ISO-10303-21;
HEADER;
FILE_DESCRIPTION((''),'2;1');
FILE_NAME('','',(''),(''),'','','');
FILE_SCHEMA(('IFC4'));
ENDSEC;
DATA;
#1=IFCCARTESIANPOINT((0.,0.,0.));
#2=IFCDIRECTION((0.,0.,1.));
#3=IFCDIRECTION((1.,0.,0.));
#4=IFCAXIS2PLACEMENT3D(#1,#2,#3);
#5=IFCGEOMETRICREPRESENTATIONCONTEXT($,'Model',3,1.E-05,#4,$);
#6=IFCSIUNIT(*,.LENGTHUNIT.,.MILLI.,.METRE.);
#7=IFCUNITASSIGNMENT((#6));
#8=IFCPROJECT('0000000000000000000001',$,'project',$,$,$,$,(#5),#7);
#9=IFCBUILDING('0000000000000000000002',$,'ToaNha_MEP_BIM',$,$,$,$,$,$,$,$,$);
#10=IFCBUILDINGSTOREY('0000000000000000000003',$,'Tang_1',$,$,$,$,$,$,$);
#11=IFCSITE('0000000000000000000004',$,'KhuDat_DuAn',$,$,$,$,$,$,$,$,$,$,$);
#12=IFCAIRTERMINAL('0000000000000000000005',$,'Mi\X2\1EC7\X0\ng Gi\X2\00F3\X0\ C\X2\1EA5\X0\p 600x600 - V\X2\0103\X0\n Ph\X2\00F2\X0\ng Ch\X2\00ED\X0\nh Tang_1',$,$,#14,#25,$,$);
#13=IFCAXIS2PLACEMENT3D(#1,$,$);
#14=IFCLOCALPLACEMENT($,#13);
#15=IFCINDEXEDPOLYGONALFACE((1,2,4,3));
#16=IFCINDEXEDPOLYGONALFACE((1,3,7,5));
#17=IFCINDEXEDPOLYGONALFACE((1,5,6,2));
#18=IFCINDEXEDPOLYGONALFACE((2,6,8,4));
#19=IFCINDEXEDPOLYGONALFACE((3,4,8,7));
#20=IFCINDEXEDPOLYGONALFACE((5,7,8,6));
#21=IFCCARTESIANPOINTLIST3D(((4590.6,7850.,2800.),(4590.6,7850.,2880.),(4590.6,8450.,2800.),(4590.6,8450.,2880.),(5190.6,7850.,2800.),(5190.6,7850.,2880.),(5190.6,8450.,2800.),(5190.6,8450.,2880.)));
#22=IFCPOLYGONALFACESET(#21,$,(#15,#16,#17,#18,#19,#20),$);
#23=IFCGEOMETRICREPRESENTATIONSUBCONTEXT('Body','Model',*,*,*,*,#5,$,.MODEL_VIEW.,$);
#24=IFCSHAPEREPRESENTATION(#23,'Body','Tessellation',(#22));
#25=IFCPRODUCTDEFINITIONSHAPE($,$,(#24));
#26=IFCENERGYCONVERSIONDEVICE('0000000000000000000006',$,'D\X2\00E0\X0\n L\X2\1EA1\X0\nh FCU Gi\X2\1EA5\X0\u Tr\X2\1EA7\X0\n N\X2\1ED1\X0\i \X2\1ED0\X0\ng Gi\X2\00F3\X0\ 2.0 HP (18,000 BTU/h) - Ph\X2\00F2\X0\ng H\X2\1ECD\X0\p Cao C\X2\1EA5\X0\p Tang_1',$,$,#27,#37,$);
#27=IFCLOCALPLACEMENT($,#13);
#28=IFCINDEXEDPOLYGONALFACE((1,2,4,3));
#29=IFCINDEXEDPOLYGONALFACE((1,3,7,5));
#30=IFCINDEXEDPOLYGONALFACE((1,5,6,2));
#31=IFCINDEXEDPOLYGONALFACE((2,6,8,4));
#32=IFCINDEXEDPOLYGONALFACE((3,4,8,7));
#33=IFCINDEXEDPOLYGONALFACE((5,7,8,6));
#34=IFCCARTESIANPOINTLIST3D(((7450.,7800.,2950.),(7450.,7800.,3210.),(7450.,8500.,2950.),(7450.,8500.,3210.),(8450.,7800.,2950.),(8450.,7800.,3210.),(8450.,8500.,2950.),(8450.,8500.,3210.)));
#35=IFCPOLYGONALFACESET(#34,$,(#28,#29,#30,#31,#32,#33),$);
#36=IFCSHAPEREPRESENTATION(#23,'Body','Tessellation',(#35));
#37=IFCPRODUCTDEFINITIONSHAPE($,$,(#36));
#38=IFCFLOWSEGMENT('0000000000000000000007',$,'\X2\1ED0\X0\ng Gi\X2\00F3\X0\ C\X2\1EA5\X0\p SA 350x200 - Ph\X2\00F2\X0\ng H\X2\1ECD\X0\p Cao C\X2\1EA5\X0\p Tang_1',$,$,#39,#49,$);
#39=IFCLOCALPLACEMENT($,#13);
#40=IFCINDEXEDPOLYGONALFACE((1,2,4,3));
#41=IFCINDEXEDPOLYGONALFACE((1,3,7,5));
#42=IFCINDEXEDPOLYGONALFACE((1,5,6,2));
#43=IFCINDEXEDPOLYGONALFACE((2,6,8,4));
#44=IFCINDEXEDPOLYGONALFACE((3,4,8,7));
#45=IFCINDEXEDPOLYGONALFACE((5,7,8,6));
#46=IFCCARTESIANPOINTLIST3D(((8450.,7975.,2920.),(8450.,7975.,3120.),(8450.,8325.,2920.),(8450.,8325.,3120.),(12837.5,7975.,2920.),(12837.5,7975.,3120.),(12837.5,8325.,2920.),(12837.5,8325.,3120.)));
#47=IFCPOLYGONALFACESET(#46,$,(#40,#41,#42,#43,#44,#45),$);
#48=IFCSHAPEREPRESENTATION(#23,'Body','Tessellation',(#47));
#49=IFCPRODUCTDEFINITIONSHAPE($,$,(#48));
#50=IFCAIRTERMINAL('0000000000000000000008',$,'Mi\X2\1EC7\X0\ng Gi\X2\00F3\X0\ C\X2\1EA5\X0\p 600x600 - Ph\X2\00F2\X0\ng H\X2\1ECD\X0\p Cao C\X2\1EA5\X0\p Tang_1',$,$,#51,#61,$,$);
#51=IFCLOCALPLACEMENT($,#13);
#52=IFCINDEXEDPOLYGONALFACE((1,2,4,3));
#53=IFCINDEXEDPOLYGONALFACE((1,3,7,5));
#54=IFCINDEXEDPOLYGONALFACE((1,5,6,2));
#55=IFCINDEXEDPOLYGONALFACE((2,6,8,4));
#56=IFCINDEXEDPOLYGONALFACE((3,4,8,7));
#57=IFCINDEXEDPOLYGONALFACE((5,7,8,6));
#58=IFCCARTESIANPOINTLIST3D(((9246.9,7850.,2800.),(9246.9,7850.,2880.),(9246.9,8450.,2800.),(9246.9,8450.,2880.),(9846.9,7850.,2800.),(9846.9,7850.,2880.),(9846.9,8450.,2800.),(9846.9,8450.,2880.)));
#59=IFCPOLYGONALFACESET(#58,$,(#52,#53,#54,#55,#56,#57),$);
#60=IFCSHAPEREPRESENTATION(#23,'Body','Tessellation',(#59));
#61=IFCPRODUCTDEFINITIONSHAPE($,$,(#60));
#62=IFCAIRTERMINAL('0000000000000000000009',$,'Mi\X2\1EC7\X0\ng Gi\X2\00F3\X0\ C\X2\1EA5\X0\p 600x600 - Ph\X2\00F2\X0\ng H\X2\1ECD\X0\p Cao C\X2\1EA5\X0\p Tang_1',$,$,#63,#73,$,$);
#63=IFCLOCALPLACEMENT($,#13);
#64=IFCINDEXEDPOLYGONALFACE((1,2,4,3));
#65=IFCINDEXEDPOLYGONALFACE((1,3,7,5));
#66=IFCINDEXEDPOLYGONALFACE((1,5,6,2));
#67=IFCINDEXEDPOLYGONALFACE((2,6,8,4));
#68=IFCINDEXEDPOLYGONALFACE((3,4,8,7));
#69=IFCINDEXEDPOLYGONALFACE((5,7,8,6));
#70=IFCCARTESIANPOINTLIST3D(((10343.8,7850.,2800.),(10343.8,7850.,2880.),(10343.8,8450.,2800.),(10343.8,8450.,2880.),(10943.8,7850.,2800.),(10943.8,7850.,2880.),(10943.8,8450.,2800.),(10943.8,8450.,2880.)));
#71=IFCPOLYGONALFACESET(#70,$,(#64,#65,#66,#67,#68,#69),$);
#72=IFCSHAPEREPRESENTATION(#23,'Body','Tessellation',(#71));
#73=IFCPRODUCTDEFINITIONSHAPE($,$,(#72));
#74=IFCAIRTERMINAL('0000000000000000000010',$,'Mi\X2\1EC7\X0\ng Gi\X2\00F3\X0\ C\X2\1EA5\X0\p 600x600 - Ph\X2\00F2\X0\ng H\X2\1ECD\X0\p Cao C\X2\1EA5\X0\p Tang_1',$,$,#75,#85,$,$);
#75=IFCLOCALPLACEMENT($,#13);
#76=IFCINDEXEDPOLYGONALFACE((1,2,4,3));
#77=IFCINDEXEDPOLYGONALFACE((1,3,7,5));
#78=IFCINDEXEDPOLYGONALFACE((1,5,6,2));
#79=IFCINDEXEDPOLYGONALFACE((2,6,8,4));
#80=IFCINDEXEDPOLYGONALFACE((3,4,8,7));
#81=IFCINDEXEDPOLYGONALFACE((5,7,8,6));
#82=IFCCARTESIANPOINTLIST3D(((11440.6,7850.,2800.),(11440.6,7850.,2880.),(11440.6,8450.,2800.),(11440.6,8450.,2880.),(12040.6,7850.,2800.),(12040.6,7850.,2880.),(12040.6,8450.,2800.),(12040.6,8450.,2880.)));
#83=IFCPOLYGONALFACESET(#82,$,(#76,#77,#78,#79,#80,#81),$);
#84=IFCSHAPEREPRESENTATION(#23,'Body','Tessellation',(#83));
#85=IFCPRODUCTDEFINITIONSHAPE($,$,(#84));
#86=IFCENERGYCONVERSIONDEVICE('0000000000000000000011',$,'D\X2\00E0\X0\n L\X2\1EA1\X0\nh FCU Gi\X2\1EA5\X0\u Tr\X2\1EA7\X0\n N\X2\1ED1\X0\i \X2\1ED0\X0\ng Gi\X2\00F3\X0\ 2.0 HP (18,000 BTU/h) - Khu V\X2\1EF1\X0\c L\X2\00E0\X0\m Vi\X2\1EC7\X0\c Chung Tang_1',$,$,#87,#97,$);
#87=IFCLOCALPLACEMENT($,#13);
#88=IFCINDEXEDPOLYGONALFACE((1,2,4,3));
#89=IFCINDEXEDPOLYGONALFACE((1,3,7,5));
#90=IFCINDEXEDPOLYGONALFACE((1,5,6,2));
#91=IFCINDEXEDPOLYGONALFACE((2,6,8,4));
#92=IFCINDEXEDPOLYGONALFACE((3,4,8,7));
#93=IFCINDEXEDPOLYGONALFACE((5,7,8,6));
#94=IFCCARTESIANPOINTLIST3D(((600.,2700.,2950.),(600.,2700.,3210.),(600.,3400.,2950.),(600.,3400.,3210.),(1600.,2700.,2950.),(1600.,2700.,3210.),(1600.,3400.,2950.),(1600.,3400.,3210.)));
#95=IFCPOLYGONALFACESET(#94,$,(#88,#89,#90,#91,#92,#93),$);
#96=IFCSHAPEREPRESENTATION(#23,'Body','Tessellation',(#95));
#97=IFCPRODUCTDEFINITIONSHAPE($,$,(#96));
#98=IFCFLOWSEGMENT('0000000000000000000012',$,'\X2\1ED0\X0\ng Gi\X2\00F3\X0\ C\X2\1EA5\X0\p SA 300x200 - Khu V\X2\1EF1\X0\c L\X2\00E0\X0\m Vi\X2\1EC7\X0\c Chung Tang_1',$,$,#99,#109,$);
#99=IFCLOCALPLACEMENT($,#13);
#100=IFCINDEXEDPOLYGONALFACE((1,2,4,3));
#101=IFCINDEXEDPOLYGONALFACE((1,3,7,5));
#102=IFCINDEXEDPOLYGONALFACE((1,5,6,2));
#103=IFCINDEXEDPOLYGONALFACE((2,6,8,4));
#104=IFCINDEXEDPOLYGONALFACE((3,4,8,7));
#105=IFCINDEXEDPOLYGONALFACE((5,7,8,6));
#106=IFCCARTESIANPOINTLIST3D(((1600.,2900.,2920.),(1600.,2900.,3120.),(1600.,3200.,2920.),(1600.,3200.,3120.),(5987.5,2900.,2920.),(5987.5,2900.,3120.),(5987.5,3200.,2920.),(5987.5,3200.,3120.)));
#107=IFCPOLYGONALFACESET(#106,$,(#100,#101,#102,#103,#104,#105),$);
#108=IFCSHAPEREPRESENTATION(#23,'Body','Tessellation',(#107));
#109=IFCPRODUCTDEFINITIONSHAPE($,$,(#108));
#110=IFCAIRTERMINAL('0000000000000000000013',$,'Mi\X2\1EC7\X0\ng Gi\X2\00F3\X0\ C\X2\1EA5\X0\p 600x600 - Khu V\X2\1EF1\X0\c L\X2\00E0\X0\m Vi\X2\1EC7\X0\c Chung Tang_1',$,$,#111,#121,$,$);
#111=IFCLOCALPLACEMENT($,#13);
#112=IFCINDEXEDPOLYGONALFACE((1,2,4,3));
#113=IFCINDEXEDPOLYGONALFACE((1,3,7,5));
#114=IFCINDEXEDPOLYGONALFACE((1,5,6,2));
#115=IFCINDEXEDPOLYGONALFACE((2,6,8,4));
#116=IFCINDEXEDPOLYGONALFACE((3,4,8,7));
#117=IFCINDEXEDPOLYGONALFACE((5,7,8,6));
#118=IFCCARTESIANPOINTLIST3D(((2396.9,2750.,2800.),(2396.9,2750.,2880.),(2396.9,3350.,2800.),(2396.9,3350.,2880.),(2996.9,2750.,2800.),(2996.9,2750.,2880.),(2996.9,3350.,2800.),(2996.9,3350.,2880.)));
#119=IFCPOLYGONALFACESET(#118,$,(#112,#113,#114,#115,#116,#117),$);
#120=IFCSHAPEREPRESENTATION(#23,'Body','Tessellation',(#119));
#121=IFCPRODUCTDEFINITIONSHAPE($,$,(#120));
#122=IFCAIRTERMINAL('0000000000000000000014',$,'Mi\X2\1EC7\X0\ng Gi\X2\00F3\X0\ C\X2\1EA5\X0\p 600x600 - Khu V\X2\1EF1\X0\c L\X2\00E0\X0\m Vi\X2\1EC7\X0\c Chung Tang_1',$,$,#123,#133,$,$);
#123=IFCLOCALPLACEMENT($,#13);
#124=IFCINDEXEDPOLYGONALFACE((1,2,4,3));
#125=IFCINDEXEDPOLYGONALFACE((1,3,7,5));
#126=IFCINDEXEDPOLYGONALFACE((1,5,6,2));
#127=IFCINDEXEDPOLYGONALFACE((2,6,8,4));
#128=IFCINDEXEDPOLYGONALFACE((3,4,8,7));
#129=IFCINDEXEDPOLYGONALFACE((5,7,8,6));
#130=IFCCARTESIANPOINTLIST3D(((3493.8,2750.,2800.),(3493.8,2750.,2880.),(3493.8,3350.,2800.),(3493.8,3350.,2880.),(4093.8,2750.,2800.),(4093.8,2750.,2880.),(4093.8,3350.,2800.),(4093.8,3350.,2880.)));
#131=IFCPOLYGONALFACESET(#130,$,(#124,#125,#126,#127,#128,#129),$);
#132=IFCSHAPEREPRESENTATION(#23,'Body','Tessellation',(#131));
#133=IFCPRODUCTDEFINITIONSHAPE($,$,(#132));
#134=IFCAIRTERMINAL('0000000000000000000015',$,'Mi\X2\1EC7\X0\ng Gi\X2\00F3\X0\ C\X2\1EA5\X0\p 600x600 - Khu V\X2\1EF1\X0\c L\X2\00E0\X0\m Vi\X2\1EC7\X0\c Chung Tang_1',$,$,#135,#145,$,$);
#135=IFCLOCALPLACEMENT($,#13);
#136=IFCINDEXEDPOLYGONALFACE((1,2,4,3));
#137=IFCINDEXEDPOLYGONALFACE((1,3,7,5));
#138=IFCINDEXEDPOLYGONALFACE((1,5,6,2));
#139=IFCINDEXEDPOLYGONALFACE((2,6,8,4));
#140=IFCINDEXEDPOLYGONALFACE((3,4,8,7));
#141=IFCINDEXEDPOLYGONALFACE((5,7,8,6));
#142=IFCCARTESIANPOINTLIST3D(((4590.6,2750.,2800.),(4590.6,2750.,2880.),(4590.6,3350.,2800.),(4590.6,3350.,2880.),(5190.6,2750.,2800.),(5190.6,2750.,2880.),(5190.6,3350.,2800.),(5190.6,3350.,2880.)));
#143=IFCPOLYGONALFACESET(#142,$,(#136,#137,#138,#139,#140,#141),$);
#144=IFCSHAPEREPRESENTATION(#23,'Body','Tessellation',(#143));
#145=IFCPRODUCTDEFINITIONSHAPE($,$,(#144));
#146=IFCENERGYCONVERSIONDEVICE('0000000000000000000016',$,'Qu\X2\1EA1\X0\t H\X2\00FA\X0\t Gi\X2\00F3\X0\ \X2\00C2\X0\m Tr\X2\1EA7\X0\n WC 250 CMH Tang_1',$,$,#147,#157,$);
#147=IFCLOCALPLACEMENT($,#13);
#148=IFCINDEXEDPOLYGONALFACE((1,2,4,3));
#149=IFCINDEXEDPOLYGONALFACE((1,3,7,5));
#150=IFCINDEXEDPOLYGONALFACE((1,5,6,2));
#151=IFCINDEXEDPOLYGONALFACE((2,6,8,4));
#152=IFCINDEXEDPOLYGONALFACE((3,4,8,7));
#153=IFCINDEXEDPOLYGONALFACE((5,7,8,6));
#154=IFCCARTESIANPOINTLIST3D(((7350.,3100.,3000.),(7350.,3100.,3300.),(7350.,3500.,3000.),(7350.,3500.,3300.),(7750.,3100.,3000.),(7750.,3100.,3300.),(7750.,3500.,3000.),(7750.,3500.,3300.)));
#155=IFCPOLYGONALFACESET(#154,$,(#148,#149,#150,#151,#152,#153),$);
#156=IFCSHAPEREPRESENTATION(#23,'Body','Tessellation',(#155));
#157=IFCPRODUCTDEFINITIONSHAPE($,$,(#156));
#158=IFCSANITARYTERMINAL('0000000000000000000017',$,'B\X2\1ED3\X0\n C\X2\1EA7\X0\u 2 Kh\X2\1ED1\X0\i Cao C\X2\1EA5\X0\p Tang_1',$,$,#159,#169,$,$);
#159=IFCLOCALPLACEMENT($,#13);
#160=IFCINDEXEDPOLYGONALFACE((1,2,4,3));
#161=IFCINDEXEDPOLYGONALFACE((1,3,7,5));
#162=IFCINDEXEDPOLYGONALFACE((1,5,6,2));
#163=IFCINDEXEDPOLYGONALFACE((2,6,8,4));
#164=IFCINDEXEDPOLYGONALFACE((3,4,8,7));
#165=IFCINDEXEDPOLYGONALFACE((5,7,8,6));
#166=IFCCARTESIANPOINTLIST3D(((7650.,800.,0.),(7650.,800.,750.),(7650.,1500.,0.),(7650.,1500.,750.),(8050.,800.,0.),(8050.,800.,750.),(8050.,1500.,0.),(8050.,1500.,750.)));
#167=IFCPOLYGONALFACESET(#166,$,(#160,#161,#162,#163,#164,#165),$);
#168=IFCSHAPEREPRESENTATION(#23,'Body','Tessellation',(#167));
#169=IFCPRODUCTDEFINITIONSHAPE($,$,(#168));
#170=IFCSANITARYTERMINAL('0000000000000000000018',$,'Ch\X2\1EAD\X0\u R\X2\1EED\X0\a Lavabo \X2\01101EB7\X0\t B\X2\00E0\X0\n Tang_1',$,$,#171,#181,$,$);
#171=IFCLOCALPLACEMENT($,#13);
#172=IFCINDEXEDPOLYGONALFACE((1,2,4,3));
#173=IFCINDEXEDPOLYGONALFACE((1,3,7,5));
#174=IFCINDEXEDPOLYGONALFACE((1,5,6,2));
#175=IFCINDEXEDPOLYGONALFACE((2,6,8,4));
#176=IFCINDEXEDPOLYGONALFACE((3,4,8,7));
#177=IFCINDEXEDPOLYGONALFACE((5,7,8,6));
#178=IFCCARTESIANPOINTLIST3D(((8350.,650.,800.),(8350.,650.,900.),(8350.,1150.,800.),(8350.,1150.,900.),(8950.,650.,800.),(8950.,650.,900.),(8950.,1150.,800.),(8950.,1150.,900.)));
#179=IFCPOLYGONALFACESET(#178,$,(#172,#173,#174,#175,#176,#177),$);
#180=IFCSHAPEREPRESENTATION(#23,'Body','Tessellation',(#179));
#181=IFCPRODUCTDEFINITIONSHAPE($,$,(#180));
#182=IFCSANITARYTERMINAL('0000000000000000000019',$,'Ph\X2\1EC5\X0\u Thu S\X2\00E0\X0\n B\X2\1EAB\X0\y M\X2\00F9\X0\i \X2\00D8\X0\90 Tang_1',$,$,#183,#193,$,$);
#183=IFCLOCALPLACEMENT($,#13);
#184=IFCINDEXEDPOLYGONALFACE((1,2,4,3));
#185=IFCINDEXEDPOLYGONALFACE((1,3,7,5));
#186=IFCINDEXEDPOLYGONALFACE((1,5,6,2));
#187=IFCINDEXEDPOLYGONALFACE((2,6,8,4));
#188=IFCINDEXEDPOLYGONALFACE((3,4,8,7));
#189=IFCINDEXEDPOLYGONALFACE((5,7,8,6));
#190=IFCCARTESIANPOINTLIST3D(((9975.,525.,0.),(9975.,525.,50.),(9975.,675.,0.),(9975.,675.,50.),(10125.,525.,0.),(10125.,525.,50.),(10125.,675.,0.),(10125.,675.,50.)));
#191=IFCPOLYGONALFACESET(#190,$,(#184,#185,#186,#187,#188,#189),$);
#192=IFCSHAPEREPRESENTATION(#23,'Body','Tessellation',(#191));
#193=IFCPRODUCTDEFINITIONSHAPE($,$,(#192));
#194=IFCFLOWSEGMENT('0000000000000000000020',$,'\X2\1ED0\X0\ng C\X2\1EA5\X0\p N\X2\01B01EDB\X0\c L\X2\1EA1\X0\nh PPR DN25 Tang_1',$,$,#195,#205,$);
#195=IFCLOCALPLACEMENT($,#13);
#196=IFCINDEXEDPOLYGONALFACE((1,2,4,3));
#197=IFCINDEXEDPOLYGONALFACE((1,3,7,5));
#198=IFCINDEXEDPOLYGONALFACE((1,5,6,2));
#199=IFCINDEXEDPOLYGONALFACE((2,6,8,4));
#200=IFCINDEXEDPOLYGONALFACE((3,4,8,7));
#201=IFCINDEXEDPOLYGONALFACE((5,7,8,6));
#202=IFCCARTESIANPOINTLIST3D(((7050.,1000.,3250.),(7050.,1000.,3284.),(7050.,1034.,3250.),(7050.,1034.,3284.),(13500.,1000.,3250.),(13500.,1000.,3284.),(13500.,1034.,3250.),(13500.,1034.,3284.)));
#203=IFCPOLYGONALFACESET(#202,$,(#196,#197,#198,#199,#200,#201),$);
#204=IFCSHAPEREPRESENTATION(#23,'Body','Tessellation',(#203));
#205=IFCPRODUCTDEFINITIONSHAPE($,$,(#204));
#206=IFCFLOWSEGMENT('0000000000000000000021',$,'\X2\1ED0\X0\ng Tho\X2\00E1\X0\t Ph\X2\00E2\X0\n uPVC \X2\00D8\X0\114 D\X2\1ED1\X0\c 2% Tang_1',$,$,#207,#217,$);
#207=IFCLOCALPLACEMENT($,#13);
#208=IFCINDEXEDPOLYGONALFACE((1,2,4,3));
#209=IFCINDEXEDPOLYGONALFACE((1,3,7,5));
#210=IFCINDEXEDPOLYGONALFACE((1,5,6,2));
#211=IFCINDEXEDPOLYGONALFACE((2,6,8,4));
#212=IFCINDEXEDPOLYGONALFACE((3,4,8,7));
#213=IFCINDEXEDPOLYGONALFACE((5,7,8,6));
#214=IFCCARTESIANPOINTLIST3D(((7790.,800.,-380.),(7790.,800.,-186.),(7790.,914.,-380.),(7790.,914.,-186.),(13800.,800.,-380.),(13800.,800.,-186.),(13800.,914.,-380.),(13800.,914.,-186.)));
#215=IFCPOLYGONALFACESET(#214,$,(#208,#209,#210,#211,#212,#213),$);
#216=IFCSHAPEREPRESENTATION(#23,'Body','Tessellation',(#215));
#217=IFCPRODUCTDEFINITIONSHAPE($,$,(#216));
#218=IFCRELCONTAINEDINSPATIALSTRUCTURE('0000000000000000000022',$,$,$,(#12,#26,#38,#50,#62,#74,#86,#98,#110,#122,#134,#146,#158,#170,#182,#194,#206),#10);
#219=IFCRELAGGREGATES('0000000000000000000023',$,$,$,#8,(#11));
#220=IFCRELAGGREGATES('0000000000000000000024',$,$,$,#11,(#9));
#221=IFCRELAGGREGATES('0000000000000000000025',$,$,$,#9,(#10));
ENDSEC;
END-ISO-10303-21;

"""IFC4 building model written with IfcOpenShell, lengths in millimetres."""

from ifc_helpers import new_model, si_unit, frame, origin_with_axes, context, subcontext, project, spatial, polyline, outline, extrude, element, save


model = new_model("IFC4")

# Units and contexts
model_context = context("Model", 3, precision=1e-05, world=origin_with_axes())
body_context = subcontext(model_context, "Body", "Model", "MODEL_VIEW")
ifc_project = project(units=[si_unit("LENGTHUNIT", "METRE", prefix="MILLI")], contexts=[model_context])

# Site, building, storey
site = spatial("IfcSite", under=ifc_project, Name="KhuDat_DuAn")
building = spatial("IfcBuilding", under=site, Name="ToaNha_MEP_BIM")
storey = spatial("IfcBuildingStorey", under=building, Name="Tang_1")

# Air terminal
element("IfcAirTerminal", 1, inside=storey, Name="Miệng Gió Cấp 600x600 - Văn Phòng Chính Tang_1", context=body_context, shape_type="SweptSolid", body=[
    extrude(outline(polyline([(4590.6, 7850.0), (5190.6, 7850.0), (5190.6, 8450.0), (4590.6, 8450.0), (4590.6, 7850.0)])), frame((0.0, 0.0, 2800.0), z_axis=(0.0, 0.0, 1.0), x_axis=(1.0, 0.0, 0.0)), (0.0, 0.0, 1.0), 80.0),
])

# Energy conversion device
element("IfcEnergyConversionDevice", 2, inside=storey, Name="Dàn Lạnh FCU Giấu Trần Nối Ống Gió 2.0 HP (18,000 BTU/h) - Phòng Họp Cao Cấp Tang_1", context=body_context, shape_type="SweptSolid", body=[
    extrude(outline(polyline([(7450.0, 7800.0), (8450.0, 7800.0), (8450.0, 8500.0), (7450.0, 8500.0), (7450.0, 7800.0)])), frame((0.0, 0.0, 2950.0), z_axis=(0.0, 0.0, 1.0), x_axis=(1.0, 0.0, 0.0)), (0.0, 0.0, 1.0), 260.0),
])

# Flow segment
element("IfcFlowSegment", 3, inside=storey, Name="Ống Gió Cấp SA 350x200 - Phòng Họp Cao Cấp Tang_1", context=body_context, shape_type="SweptSolid", body=[
    extrude(outline(polyline([(8450.0, 7975.0), (12837.5, 7975.0), (12837.5, 8325.0), (8450.0, 8325.0), (8450.0, 7975.0)])), frame((0.0, 0.0, 2920.0), z_axis=(0.0, 0.0, 1.0), x_axis=(1.0, 0.0, 0.0)), (0.0, 0.0, 1.0), 200.0),
])

# Air terminals
element("IfcAirTerminal", 4, inside=storey, Name="Miệng Gió Cấp 600x600 - Phòng Họp Cao Cấp Tang_1", context=body_context, shape_type="SweptSolid", body=[
    extrude(outline(polyline([(9246.9, 7850.0), (9846.9, 7850.0), (9846.9, 8450.0), (9246.9, 8450.0), (9246.9, 7850.0)])), frame((0.0, 0.0, 2800.0), z_axis=(0.0, 0.0, 1.0), x_axis=(1.0, 0.0, 0.0)), (0.0, 0.0, 1.0), 80.0),
])
element("IfcAirTerminal", 5, inside=storey, Name="Miệng Gió Cấp 600x600 - Phòng Họp Cao Cấp Tang_1", context=body_context, shape_type="SweptSolid", body=[
    extrude(outline(polyline([(10343.8, 7850.0), (10943.8, 7850.0), (10943.8, 8450.0), (10343.8, 8450.0), (10343.8, 7850.0)])), frame((0.0, 0.0, 2800.0), z_axis=(0.0, 0.0, 1.0), x_axis=(1.0, 0.0, 0.0)), (0.0, 0.0, 1.0), 80.0),
])
element("IfcAirTerminal", 6, inside=storey, Name="Miệng Gió Cấp 600x600 - Phòng Họp Cao Cấp Tang_1", context=body_context, shape_type="SweptSolid", body=[
    extrude(outline(polyline([(11440.6, 7850.0), (12040.6, 7850.0), (12040.6, 8450.0), (11440.6, 8450.0), (11440.6, 7850.0)])), frame((0.0, 0.0, 2800.0), z_axis=(0.0, 0.0, 1.0), x_axis=(1.0, 0.0, 0.0)), (0.0, 0.0, 1.0), 80.0),
])

# Energy conversion device
element("IfcEnergyConversionDevice", 7, inside=storey, Name="Dàn Lạnh FCU Giấu Trần Nối Ống Gió 2.0 HP (18,000 BTU/h) - Khu Vực Làm Việc Chung Tang_1", context=body_context, shape_type="SweptSolid", body=[
    extrude(outline(polyline([(600.0, 2700.0), (1600.0, 2700.0), (1600.0, 3400.0), (600.0, 3400.0), (600.0, 2700.0)])), frame((0.0, 0.0, 2950.0), z_axis=(0.0, 0.0, 1.0), x_axis=(1.0, 0.0, 0.0)), (0.0, 0.0, 1.0), 260.0),
])

# Flow segment
element("IfcFlowSegment", 8, inside=storey, Name="Ống Gió Cấp SA 300x200 - Khu Vực Làm Việc Chung Tang_1", context=body_context, shape_type="SweptSolid", body=[
    extrude(outline(polyline([(1600.0, 2900.0), (5987.5, 2900.0), (5987.5, 3200.0), (1600.0, 3200.0), (1600.0, 2900.0)])), frame((0.0, 0.0, 2920.0), z_axis=(0.0, 0.0, 1.0), x_axis=(1.0, 0.0, 0.0)), (0.0, 0.0, 1.0), 200.0),
])

# Air terminals
element("IfcAirTerminal", 9, inside=storey, Name="Miệng Gió Cấp 600x600 - Khu Vực Làm Việc Chung Tang_1", context=body_context, shape_type="SweptSolid", body=[
    extrude(outline(polyline([(2396.9, 2750.0), (2996.9, 2750.0), (2996.9, 3350.0), (2396.9, 3350.0), (2396.9, 2750.0)])), frame((0.0, 0.0, 2800.0), z_axis=(0.0, 0.0, 1.0), x_axis=(1.0, 0.0, 0.0)), (0.0, 0.0, 1.0), 80.0),
])
element("IfcAirTerminal", 10, inside=storey, Name="Miệng Gió Cấp 600x600 - Khu Vực Làm Việc Chung Tang_1", context=body_context, shape_type="SweptSolid", body=[
    extrude(outline(polyline([(3493.8, 2750.0), (4093.8, 2750.0), (4093.8, 3350.0), (3493.8, 3350.0), (3493.8, 2750.0)])), frame((0.0, 0.0, 2800.0), z_axis=(0.0, 0.0, 1.0), x_axis=(1.0, 0.0, 0.0)), (0.0, 0.0, 1.0), 80.0),
])
element("IfcAirTerminal", 11, inside=storey, Name="Miệng Gió Cấp 600x600 - Khu Vực Làm Việc Chung Tang_1", context=body_context, shape_type="SweptSolid", body=[
    extrude(outline(polyline([(4590.6, 2750.0), (5190.6, 2750.0), (5190.6, 3350.0), (4590.6, 3350.0), (4590.6, 2750.0)])), frame((0.0, 0.0, 2800.0), z_axis=(0.0, 0.0, 1.0), x_axis=(1.0, 0.0, 0.0)), (0.0, 0.0, 1.0), 80.0),
])

# Energy conversion device
element("IfcEnergyConversionDevice", 12, inside=storey, Name="Quạt Hút Gió Âm Trần WC 250 CMH Tang_1", context=body_context, shape_type="SweptSolid", body=[
    extrude(outline(polyline([(7350.0, 3100.0), (7750.0, 3100.0), (7750.0, 3500.0), (7350.0, 3500.0), (7350.0, 3100.0)])), frame((0.0, 0.0, 3000.0), z_axis=(0.0, 0.0, 1.0), x_axis=(1.0, 0.0, 0.0)), (0.0, 0.0, 1.0), 300.0),
])

# Sanitary terminals
element("IfcSanitaryTerminal", 13, inside=storey, Name="Bồn Cầu 2 Khối Cao Cấp Tang_1", context=body_context, shape_type="SweptSolid", body=[
    extrude(outline(polyline([(7650.0, 800.0), (8050.0, 800.0), (8050.0, 1500.0), (7650.0, 1500.0), (7650.0, 800.0)])), origin_with_axes(), (0.0, 0.0, 1.0), 750.0),
])
element("IfcSanitaryTerminal", 14, inside=storey, Name="Chậu Rửa Lavabo Đặt Bàn Tang_1", context=body_context, shape_type="SweptSolid", body=[
    extrude(outline(polyline([(8350.0, 650.0), (8950.0, 650.0), (8950.0, 1150.0), (8350.0, 1150.0), (8350.0, 650.0)])), frame((0.0, 0.0, 800.0), z_axis=(0.0, 0.0, 1.0), x_axis=(1.0, 0.0, 0.0)), (0.0, 0.0, 1.0), 100.0),
])
element("IfcSanitaryTerminal", 15, inside=storey, Name="Phễu Thu Sàn Bẫy Mùi Ø90 Tang_1", context=body_context, shape_type="SweptSolid", body=[
    extrude(outline(polyline([(9975.0, 525.0), (10125.0, 525.0), (10125.0, 675.0), (9975.0, 675.0), (9975.0, 525.0)])), origin_with_axes(), (0.0, 0.0, 1.0), 50.0),
])

# Flow segments
element("IfcFlowSegment", 16, inside=storey, Name="Ống Cấp Nước Lạnh PPR DN25 Tang_1", context=body_context, shape_type="SweptSolid", body=[
    extrude(outline(polyline([(7050.0, 1000.0), (13500.0, 1000.0), (13500.0, 1034.0), (7050.0, 1034.0), (7050.0, 1000.0)])), frame((0.0, 0.0, 3250.0), z_axis=(0.0, 0.0, 1.0), x_axis=(1.0, 0.0, 0.0)), (0.0, 0.0, 1.0), 34.0),
])
element("IfcFlowSegment", 17, inside=storey, Name="Ống Thoát Phân uPVC Ø114 Dốc 2% Tang_1", context=body_context, shape_type="SweptSolid", body=[
    extrude(outline(polyline([(7790.0, 800.0), (13800.0, 800.0), (13800.0, 914.0), (7790.0, 914.0), (7790.0, 800.0)])), frame((0.0, 0.0, -380.0), z_axis=(0.0, 0.0, 1.0), x_axis=(1.0, 0.0, 0.0)), (0.0, 0.0, 1.0), 194.0),
])

save(model, "model.ifc")
